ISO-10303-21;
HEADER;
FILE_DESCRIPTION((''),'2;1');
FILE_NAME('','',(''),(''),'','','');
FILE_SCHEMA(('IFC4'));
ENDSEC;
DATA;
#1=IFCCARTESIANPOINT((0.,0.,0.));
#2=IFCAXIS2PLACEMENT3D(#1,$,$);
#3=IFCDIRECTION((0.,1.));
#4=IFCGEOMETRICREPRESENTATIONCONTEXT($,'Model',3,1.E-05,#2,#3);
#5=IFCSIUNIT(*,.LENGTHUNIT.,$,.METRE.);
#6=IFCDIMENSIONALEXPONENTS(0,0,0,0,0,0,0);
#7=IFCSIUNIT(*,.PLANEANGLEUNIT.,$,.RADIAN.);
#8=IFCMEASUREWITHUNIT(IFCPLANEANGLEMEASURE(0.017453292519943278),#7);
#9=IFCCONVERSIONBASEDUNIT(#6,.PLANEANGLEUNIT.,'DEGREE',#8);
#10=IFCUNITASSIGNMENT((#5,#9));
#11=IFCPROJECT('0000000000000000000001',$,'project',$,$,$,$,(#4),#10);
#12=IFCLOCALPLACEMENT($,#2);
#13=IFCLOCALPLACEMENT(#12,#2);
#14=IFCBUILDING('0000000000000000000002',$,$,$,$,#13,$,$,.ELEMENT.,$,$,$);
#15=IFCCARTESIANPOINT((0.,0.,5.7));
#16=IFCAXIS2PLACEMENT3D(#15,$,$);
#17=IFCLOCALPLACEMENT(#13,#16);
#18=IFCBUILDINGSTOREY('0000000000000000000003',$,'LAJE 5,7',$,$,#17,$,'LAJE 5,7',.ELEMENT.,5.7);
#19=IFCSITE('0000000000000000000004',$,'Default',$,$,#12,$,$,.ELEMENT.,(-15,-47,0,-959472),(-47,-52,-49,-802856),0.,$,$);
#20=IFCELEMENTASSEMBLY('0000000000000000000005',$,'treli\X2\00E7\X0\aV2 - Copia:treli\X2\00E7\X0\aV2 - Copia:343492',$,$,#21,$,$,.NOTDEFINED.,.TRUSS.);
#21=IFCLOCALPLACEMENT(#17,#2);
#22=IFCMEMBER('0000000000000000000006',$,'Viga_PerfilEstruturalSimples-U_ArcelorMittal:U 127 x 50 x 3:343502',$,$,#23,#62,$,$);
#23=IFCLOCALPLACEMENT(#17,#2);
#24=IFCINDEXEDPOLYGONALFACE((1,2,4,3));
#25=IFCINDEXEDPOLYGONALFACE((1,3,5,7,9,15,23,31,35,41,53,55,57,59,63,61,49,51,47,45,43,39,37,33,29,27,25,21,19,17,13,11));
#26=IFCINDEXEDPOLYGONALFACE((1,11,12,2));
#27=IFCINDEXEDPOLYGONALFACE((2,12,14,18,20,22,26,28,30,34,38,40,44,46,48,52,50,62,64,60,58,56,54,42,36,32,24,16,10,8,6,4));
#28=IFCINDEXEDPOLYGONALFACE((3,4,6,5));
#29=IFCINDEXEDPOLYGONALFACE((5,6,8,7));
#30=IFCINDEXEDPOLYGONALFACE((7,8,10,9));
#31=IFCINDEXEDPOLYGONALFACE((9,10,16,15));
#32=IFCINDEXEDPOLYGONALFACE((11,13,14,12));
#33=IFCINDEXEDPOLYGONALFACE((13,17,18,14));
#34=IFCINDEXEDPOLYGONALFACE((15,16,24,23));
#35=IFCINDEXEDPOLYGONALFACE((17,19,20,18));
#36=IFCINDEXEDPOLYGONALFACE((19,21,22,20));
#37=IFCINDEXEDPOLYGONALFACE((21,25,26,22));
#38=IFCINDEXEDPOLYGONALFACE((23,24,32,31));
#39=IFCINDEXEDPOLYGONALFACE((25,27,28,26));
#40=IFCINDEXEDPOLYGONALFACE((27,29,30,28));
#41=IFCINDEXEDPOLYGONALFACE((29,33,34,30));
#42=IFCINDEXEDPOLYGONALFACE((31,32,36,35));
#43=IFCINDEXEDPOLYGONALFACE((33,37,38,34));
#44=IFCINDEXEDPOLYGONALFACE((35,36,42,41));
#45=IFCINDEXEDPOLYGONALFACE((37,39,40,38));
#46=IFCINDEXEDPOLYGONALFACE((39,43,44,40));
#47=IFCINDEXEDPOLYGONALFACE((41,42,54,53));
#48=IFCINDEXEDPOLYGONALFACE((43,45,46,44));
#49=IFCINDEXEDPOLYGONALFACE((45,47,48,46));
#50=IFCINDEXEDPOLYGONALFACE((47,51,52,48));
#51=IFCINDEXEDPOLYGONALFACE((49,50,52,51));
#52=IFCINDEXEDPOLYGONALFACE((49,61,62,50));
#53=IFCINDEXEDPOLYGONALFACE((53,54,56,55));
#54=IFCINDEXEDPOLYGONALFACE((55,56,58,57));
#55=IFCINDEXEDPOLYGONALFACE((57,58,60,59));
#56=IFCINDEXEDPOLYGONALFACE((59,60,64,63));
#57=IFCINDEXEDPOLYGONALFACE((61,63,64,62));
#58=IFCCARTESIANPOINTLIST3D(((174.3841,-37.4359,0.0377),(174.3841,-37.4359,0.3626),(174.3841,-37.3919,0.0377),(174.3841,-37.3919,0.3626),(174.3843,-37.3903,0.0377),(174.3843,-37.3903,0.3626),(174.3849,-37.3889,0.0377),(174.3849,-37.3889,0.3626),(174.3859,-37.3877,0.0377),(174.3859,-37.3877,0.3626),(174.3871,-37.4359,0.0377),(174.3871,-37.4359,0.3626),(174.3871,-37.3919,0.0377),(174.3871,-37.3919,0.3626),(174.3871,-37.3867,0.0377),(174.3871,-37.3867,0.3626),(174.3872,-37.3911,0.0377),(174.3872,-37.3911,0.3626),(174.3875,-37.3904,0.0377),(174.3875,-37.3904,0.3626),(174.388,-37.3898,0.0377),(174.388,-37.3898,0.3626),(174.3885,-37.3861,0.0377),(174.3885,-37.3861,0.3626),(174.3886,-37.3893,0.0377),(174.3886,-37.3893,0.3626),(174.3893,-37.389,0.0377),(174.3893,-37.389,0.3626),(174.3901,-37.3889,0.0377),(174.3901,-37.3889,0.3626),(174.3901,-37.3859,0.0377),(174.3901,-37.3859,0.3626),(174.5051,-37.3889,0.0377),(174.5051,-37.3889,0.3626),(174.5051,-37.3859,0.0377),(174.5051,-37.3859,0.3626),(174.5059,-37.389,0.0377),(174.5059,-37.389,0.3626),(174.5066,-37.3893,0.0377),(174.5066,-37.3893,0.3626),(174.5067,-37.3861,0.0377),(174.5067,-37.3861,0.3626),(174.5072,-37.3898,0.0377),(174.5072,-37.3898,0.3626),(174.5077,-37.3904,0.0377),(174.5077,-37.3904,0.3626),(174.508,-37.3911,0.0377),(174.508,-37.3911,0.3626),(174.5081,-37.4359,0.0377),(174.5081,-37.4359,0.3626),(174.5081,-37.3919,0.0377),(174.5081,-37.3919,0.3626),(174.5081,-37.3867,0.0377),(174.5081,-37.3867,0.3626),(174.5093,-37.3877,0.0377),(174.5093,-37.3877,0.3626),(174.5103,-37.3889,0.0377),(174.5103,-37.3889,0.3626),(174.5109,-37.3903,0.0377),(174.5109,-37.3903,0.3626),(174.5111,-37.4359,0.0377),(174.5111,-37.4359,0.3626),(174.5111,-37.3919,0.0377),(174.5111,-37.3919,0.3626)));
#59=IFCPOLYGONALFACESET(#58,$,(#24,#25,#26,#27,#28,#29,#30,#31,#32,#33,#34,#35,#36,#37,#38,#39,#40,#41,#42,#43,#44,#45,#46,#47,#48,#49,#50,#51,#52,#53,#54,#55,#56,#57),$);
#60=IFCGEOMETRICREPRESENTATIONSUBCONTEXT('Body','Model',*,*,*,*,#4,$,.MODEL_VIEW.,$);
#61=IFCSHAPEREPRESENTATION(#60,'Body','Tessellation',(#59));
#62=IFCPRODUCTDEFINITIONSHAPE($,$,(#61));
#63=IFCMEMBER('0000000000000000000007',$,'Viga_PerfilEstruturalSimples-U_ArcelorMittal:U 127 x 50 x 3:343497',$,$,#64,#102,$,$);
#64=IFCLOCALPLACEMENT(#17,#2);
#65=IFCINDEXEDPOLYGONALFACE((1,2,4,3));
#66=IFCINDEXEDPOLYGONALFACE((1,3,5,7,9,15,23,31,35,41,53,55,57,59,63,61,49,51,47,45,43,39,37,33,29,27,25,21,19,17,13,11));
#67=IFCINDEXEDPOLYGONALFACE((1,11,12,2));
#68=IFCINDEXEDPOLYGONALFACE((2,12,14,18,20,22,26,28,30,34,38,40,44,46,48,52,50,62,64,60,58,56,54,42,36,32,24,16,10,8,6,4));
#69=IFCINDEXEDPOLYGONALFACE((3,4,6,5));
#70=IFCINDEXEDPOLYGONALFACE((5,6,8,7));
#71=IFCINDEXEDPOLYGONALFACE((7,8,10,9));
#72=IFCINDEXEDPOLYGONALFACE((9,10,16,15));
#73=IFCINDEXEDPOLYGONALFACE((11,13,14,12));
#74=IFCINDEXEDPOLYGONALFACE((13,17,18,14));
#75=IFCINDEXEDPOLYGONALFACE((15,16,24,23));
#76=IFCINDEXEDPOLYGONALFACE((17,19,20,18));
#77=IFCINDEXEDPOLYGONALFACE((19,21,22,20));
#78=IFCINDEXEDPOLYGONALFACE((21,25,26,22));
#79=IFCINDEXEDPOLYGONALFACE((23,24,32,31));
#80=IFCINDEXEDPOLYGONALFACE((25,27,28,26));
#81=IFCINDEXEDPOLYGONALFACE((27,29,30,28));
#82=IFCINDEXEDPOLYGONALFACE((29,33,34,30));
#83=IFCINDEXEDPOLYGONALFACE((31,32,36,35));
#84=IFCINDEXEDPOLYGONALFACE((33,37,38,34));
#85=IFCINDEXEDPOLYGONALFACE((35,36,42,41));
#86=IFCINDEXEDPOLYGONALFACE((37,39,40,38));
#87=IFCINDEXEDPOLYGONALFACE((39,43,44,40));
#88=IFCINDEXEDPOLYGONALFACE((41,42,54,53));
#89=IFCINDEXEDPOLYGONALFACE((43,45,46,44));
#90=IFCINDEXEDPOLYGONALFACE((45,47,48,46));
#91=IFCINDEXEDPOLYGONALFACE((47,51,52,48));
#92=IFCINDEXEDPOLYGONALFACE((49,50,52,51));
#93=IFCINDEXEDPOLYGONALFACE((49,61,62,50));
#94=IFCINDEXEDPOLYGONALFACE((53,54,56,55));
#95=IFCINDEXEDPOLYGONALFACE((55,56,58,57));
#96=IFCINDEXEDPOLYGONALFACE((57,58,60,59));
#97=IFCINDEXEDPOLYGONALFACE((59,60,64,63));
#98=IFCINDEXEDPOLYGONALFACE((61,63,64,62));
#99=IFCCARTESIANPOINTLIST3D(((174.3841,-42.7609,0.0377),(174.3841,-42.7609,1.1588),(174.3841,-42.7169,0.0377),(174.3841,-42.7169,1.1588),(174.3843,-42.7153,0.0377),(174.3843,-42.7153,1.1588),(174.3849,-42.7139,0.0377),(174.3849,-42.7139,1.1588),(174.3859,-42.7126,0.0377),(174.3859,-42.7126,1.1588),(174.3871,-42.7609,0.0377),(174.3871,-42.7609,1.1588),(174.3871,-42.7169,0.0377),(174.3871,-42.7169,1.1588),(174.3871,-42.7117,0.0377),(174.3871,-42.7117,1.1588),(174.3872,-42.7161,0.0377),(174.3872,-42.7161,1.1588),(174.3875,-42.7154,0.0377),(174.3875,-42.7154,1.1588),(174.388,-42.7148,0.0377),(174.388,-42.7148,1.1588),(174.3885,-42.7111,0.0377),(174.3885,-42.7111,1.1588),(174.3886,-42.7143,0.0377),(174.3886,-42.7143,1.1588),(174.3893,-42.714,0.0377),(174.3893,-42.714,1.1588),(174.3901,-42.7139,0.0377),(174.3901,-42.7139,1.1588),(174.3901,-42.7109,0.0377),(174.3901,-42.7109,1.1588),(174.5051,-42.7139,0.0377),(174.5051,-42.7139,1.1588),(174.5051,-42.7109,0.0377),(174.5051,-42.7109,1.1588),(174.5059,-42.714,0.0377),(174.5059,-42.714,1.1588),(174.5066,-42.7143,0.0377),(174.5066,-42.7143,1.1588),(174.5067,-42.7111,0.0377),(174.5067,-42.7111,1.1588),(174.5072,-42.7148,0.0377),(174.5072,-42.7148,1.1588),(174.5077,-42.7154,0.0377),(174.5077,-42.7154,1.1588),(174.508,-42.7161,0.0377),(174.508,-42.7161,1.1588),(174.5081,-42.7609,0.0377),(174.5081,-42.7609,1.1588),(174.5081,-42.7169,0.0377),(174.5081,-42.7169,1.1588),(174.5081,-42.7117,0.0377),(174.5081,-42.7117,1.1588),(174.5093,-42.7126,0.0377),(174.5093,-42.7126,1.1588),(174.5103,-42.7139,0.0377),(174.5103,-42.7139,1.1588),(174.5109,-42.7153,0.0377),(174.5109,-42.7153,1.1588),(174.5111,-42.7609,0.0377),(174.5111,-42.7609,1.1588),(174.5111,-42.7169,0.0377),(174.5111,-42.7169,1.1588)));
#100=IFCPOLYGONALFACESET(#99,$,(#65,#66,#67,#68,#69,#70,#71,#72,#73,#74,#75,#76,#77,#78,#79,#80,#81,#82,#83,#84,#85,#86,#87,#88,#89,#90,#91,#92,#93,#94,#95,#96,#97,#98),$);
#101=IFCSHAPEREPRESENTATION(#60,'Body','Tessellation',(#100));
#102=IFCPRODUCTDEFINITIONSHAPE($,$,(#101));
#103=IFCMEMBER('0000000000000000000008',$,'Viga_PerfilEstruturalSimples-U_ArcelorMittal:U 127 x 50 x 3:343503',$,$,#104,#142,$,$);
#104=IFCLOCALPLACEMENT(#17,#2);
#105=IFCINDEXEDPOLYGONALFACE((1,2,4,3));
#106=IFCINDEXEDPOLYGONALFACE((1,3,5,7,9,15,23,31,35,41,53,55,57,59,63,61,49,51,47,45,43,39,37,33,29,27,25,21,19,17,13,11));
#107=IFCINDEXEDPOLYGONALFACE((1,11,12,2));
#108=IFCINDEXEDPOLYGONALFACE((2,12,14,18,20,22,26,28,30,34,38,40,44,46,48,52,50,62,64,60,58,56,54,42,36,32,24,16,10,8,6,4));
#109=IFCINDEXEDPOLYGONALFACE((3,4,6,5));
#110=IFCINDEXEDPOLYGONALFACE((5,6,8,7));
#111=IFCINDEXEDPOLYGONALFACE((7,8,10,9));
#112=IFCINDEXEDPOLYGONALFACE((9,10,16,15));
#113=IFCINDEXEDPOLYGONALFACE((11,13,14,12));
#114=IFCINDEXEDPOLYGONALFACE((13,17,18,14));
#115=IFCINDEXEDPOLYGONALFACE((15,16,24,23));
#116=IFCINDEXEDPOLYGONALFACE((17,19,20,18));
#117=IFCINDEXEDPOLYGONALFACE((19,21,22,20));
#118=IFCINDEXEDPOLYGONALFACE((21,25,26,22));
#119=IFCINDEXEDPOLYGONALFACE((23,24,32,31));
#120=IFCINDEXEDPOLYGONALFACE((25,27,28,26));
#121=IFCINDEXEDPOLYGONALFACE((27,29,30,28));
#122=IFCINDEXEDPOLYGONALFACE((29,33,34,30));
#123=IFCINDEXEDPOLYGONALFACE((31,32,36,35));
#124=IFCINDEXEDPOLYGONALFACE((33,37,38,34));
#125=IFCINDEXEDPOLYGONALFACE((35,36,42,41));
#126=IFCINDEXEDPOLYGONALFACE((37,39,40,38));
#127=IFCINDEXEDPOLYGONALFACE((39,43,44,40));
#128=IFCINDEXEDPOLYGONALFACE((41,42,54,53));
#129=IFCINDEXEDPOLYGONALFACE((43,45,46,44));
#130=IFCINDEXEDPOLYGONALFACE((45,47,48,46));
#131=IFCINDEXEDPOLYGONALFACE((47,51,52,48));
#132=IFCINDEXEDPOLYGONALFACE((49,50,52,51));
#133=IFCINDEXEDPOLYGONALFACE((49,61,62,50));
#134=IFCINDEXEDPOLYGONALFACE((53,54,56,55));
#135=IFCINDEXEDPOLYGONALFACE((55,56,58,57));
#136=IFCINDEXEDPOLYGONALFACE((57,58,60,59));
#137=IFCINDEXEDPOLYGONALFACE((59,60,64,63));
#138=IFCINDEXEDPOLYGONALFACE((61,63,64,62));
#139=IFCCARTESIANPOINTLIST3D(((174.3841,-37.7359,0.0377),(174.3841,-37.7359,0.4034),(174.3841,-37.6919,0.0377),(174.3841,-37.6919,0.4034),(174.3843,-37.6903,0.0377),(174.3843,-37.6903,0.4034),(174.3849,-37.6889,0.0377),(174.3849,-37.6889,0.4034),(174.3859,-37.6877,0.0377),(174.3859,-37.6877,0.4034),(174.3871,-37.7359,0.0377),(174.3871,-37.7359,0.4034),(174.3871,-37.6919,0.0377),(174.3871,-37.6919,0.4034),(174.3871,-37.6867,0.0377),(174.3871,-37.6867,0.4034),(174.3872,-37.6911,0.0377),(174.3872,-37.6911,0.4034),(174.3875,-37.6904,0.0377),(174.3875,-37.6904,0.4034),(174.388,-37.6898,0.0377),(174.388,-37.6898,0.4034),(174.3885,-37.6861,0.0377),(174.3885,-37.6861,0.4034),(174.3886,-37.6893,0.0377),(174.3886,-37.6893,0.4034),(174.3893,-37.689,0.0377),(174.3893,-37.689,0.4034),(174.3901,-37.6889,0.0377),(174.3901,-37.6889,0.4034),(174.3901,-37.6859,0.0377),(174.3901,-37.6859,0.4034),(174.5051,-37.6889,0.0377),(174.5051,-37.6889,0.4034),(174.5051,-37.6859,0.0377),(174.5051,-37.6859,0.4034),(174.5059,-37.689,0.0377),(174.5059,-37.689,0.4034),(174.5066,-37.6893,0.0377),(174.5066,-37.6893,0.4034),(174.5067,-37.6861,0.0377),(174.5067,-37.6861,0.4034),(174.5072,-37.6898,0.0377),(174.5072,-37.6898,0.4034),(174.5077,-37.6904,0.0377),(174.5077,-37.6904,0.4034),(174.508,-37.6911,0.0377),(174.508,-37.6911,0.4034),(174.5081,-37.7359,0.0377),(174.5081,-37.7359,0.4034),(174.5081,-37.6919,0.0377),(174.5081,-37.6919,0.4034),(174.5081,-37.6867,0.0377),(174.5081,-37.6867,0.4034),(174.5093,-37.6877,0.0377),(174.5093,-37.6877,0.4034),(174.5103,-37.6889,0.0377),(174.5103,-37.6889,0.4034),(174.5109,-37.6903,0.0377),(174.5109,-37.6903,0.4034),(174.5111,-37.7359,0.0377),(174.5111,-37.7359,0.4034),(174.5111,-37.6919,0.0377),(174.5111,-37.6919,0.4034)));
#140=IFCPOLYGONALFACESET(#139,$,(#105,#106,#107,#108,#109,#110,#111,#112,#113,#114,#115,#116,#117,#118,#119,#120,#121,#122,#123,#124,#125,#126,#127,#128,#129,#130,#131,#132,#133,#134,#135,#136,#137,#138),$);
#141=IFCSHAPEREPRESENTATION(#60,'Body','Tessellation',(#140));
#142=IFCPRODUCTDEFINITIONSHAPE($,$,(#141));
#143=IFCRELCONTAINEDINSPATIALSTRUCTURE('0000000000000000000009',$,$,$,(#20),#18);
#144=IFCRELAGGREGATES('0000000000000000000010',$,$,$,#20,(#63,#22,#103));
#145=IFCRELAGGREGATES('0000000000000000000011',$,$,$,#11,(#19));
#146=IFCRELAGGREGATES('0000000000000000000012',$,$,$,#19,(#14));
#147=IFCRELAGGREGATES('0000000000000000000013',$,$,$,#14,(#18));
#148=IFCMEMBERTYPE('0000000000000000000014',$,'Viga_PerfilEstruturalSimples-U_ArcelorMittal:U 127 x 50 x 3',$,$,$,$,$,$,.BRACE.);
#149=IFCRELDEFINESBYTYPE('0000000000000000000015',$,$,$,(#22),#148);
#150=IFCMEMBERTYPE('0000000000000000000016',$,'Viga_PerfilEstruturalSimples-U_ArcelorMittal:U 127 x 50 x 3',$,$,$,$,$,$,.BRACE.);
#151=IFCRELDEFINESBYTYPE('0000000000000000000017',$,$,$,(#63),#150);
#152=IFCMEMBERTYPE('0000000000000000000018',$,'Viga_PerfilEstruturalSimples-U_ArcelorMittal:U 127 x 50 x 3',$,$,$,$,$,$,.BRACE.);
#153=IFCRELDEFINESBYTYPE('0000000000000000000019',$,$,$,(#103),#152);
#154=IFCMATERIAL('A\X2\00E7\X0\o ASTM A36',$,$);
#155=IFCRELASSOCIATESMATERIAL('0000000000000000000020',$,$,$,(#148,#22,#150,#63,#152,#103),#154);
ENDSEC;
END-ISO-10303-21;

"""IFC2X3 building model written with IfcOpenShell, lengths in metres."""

from ifc_helpers import new_model, entity, si_unit, converted_unit, direction, frame, frame_2d, origin, place, context, subcontext, project, spatial, polyline, circle_curve, parameter, trimmed, segment, composite_curve, outline, extrude, source, transform, mapped, material, type_object, type_shapes, element, aggregate, save


model = new_model("IFC2X3")

# Units and contexts
model_context = context("Model", 3, precision=1e-05, world=origin(), true_north=direction((0.0, 1.0)))
body_context = subcontext(model_context, "Body", "Model", "MODEL_VIEW")
ifc_project = project(units=[si_unit("LENGTHUNIT", "METRE"), converted_unit("PLANEANGLEUNIT", "DEGREE", entity("IfcPlaneAngleMeasure", 0.017453292519943278), si_unit("PLANEANGLEUNIT", "RADIAN"), dimensions=[0, 0, 0, 0, 0, 0, 0])], contexts=[model_context])

# Site, building, storey
site_placement = place(None, origin())
site = spatial("IfcSite", under=ifc_project, at=site_placement, Name="Default", CompositionType="ELEMENT", RefLatitude=(-15, -47, 0, -959472), RefLongitude=(-47, -52, -49, -802856), RefElevation=0.0)
building_placement = place(site_placement, origin())
building = spatial("IfcBuilding", under=site, at=building_placement, CompositionType="ELEMENT")
storey_placement = place(building_placement, frame((0.0, 0.0, 5.7)))
storey = spatial("IfcBuildingStorey", under=building, at=storey_placement, Name="LAJE 5,7", LongName="LAJE 5,7", CompositionType="ELEMENT", Elevation=5.7)

# Element assembly, members
assembly_1_placement = place(storey_placement, origin())
assembly_1 = element("IfcElementAssembly", 1, at=assembly_1_placement, inside=storey, Name="treliçaV2 - Copia:treliçaV2 - Copia:343492", AssemblyPlace="NOTDEFINED", PredefinedType="TRUSS")
ifc_material = material(Name="Aço ASTM A36")
member_type_1 = type_object("IfcMemberType", Name="Viga_PerfilEstruturalSimples-U_ArcelorMittal:U 127 x 50 x 3", PredefinedType="BRACE", material=ifc_material)
shared_shape_1 = source(origin(), body_context, "Body", "SweptSolid", [
    extrude(outline(composite_curve([segment(polyline([(-0.0575, -0.0192), (0.0575, -0.0192)]), True, "CONTINUOUS"), segment(trimmed(circle_curve(frame_2d((0.0575, -0.0132), x_axis=(0.0, 1.0)), 0.006), [parameter(180.0)], [parameter(270.0)], True, "PARAMETER"), True, "CONTINUOUS"), segment(polyline([(0.0635, -0.0132), (0.0635, 0.0308)]), True, "CONTINUOUS"), segment(polyline([(0.0635, 0.0308), (0.0605, 0.0308)]), True, "CONTINUOUS"), segment(polyline([(0.0605, 0.0308), (0.0605, -0.0132)]), True, "CONTINUOUS"), segment(trimmed(circle_curve(frame_2d((0.0575, -0.0132), x_axis=(0.0, 1.0)), 0.003), [parameter(180.0)], [parameter(270.0)], True, "PARAMETER"), False, "CONTINUOUS"), segment(polyline([(0.0575, -0.0162), (-0.0575, -0.0162)]), True, "CONTINUOUS"), segment(trimmed(circle_curve(frame_2d((-0.0575, -0.0132), x_axis=(0.0, 1.0)), 0.003), [parameter(90.0)], [parameter(180.0)], True, "PARAMETER"), False, "CONTINUOUS"), segment(polyline([(-0.0605, -0.0132), (-0.0605, 0.0308)]), True, "CONTINUOUS"), segment(polyline([(-0.0605, 0.0308), (-0.0635, 0.0308)]), True, "CONTINUOUS"), segment(polyline([(-0.0635, 0.0308), (-0.0635, -0.0132)]), True, "CONTINUOUS"), segment(trimmed(circle_curve(frame_2d((-0.0575, -0.0132), x_axis=(0.0, 1.0)), 0.006), [parameter(90.0)], [parameter(180.0)], True, "PARAMETER"), True, "CONTINUOUS")], self_intersect=False)), frame((-0.1623, -0.0058, 0.0), z_axis=(1.0, 0.0, 0.0), x_axis=(0.0, 0.0, -1.0)), (0.0, 0.0, 1.0), 0.3249),
])
type_shapes(member_type_1, [shared_shape_1])
member_1_placement = place(assembly_1_placement, frame((174.4476, -37.4109, 0.2), z_axis=(1.0, 0.0, 0.0), x_axis=(0.0, 0.0, 1.0)))
member_1 = element("IfcMember", 2, at=member_1_placement, type_object=member_type_1, material=ifc_material, Name="Viga_PerfilEstruturalSimples-U_ArcelorMittal:U 127 x 50 x 3:343502", context=body_context, shape_type="MappedRepresentation", body=[
    mapped(shared_shape_1, transform((0.0, 0.0, 0.0), scale=1.0)),
])
member_type_2 = type_object("IfcMemberType", Name="Viga_PerfilEstruturalSimples-U_ArcelorMittal:U 127 x 50 x 3", PredefinedType="BRACE", material=ifc_material)
shared_shape_2 = source(origin(), body_context, "Body", "SweptSolid", [
    extrude(outline(composite_curve([segment(polyline([(-0.0575, -0.0192), (0.0575, -0.0192)]), True, "CONTINUOUS"), segment(trimmed(circle_curve(frame_2d((0.0575, -0.0132), x_axis=(0.0, 1.0)), 0.006), [parameter(180.0)], [parameter(270.0)], True, "PARAMETER"), True, "CONTINUOUS"), segment(polyline([(0.0635, -0.0132), (0.0635, 0.0308)]), True, "CONTINUOUS"), segment(polyline([(0.0635, 0.0308), (0.0605, 0.0308)]), True, "CONTINUOUS"), segment(polyline([(0.0605, 0.0308), (0.0605, -0.0132)]), True, "CONTINUOUS"), segment(trimmed(circle_curve(frame_2d((0.0575, -0.0132), x_axis=(0.0, 1.0)), 0.003), [parameter(180.0)], [parameter(270.0)], True, "PARAMETER"), False, "CONTINUOUS"), segment(polyline([(0.0575, -0.0162), (-0.0575, -0.0162)]), True, "CONTINUOUS"), segment(trimmed(circle_curve(frame_2d((-0.0575, -0.0132), x_axis=(0.0, 1.0)), 0.003), [parameter(90.0)], [parameter(180.0)], True, "PARAMETER"), False, "CONTINUOUS"), segment(polyline([(-0.0605, -0.0132), (-0.0605, 0.0308)]), True, "CONTINUOUS"), segment(polyline([(-0.0605, 0.0308), (-0.0635, 0.0308)]), True, "CONTINUOUS"), segment(polyline([(-0.0635, 0.0308), (-0.0635, -0.0132)]), True, "CONTINUOUS"), segment(trimmed(circle_curve(frame_2d((-0.0575, -0.0132), x_axis=(0.0, 1.0)), 0.006), [parameter(90.0)], [parameter(180.0)], True, "PARAMETER"), True, "CONTINUOUS")], self_intersect=False)), frame((-0.5626, -0.0058, 0.0), z_axis=(1.0, 0.0, 0.0), x_axis=(0.0, 0.0, -1.0)), (0.0, 0.0, 1.0), 1.1211),
])
type_shapes(member_type_2, [shared_shape_2])
member_2_placement = place(assembly_1_placement, frame((174.4476, -42.7359, 0.6003), z_axis=(1.0, 0.0, 0.0), x_axis=(0.0, 0.0, 1.0)))
member_2 = element("IfcMember", 3, at=member_2_placement, type_object=member_type_2, material=ifc_material, Name="Viga_PerfilEstruturalSimples-U_ArcelorMittal:U 127 x 50 x 3:343497", context=body_context, shape_type="MappedRepresentation", body=[
    mapped(shared_shape_2, transform((0.0, 0.0, 0.0), scale=1.0)),
])
member_type_3 = type_object("IfcMemberType", Name="Viga_PerfilEstruturalSimples-U_ArcelorMittal:U 127 x 50 x 3", PredefinedType="BRACE", material=ifc_material)
shared_shape_3 = source(origin(), body_context, "Body", "SweptSolid", [
    extrude(outline(composite_curve([segment(polyline([(-0.0575, -0.0192), (0.0575, -0.0192)]), True, "CONTINUOUS"), segment(trimmed(circle_curve(frame_2d((0.0575, -0.0132), x_axis=(0.0, 1.0)), 0.006), [parameter(180.0)], [parameter(270.0)], True, "PARAMETER"), True, "CONTINUOUS"), segment(polyline([(0.0635, -0.0132), (0.0635, 0.0308)]), True, "CONTINUOUS"), segment(polyline([(0.0635, 0.0308), (0.0605, 0.0308)]), True, "CONTINUOUS"), segment(polyline([(0.0605, 0.0308), (0.0605, -0.0132)]), True, "CONTINUOUS"), segment(trimmed(circle_curve(frame_2d((0.0575, -0.0132), x_axis=(0.0, 1.0)), 0.003), [parameter(180.0)], [parameter(270.0)], True, "PARAMETER"), False, "CONTINUOUS"), segment(polyline([(0.0575, -0.0162), (-0.0575, -0.0162)]), True, "CONTINUOUS"), segment(trimmed(circle_curve(frame_2d((-0.0575, -0.0132), x_axis=(0.0, 1.0)), 0.003), [parameter(90.0)], [parameter(180.0)], True, "PARAMETER"), False, "CONTINUOUS"), segment(polyline([(-0.0605, -0.0132), (-0.0605, 0.0308)]), True, "CONTINUOUS"), segment(polyline([(-0.0605, 0.0308), (-0.0635, 0.0308)]), True, "CONTINUOUS"), segment(polyline([(-0.0635, 0.0308), (-0.0635, -0.0132)]), True, "CONTINUOUS"), segment(trimmed(circle_curve(frame_2d((-0.0575, -0.0132), x_axis=(0.0, 1.0)), 0.006), [parameter(90.0)], [parameter(180.0)], True, "PARAMETER"), True, "CONTINUOUS")], self_intersect=False)), frame((-0.1849, -0.0058, 0.0), z_axis=(1.0, 0.0, 0.0), x_axis=(0.0, 0.0, -1.0)), (0.0, 0.0, 1.0), 0.3657),
])
type_shapes(member_type_3, [shared_shape_3])
member_3_placement = place(assembly_1_placement, frame((174.4476, -37.7109, 0.2226), z_axis=(1.0, 0.0, 0.0), x_axis=(0.0, 0.0, 1.0)))
member_3 = element("IfcMember", 4, at=member_3_placement, type_object=member_type_3, material=ifc_material, Name="Viga_PerfilEstruturalSimples-U_ArcelorMittal:U 127 x 50 x 3:343503", context=body_context, shape_type="MappedRepresentation", body=[
    mapped(shared_shape_3, transform((0.0, 0.0, 0.0), scale=1.0)),
])

aggregate(assembly_1, [member_2, member_1, member_3])

save(model, "model.ifc")
